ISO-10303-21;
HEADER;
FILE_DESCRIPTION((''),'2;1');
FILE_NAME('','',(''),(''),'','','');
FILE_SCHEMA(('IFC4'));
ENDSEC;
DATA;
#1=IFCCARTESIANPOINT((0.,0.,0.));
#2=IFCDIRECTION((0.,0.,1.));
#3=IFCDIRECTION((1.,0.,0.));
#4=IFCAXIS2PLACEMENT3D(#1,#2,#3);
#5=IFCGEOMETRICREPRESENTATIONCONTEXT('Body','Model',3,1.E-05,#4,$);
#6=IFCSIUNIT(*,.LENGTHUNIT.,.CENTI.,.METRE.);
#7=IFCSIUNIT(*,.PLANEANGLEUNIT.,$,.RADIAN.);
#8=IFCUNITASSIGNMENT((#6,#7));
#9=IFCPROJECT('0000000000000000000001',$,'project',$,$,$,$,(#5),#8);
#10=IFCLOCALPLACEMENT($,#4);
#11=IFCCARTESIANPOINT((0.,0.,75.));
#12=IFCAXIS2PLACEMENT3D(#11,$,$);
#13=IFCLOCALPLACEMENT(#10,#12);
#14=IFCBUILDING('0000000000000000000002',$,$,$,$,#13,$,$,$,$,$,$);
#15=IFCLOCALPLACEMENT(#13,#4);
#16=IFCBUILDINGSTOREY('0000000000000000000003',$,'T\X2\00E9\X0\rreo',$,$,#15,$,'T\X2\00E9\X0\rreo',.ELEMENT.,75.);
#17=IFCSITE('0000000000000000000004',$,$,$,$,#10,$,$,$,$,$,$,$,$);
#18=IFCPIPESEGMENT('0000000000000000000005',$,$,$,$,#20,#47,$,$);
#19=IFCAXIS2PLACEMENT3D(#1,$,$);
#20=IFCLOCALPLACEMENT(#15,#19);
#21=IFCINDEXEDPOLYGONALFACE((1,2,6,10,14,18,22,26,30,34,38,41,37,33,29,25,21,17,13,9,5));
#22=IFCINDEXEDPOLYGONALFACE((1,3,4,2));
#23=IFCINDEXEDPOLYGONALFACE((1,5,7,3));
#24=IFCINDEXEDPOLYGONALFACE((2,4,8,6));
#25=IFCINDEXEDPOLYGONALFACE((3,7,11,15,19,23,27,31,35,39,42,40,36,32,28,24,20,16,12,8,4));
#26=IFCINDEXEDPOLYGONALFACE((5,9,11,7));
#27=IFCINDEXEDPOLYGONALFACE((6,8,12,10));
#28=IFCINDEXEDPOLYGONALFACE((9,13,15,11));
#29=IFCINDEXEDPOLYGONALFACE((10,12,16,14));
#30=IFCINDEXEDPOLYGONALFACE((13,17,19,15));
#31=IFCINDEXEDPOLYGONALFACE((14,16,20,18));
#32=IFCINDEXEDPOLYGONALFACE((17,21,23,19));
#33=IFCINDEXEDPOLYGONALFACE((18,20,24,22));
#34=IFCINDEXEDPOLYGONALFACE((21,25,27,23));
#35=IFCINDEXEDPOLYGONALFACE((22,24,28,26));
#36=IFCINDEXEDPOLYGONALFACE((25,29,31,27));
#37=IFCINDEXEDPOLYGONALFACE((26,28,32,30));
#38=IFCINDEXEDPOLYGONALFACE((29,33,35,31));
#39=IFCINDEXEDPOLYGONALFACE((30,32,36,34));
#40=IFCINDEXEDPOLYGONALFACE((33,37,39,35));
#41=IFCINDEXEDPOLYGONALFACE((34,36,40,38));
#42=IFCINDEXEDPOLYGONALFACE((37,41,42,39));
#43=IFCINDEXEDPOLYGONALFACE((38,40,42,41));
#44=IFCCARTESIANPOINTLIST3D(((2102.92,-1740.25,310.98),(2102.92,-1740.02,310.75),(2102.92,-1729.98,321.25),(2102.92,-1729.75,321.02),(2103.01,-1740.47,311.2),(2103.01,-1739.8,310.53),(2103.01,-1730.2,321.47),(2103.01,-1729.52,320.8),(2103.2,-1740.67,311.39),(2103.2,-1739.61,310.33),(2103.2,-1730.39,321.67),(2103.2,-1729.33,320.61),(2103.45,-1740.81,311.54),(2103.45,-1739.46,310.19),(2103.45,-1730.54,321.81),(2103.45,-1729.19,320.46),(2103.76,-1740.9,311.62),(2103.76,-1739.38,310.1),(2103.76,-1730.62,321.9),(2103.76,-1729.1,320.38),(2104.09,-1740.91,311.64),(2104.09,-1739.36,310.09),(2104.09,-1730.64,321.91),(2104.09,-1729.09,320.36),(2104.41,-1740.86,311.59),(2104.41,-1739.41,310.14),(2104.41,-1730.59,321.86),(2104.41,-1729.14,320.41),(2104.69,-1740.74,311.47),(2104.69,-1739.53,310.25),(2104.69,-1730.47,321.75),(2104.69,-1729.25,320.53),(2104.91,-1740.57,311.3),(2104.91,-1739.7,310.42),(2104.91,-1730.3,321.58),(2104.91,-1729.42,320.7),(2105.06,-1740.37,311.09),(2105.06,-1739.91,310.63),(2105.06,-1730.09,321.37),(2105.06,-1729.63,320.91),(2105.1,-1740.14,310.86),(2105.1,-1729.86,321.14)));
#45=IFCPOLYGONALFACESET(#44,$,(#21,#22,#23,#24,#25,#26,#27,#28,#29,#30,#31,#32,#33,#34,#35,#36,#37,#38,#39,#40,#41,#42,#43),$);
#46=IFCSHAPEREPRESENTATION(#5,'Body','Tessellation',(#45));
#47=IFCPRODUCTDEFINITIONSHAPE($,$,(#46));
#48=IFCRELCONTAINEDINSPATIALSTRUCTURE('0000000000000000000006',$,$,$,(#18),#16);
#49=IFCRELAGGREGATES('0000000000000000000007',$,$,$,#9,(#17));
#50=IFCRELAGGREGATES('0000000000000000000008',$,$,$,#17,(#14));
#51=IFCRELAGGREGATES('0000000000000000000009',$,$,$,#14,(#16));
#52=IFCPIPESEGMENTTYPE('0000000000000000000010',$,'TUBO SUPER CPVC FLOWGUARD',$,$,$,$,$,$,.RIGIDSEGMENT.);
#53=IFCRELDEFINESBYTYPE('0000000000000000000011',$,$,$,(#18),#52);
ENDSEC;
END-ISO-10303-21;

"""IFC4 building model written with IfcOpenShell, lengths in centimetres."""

from ifc_helpers import new_model, si_unit, frame, origin_with_axes, origin_2d_with_axis, place, context, project, spatial, circle, extrude, type_object, element, save


model = new_model("IFC4")

# Units and contexts
model_context = context("Model", 3, precision=1e-05, world=origin_with_axes(), identifier="Body")
ifc_project = project(units=[si_unit("LENGTHUNIT", "METRE", prefix="CENTI"), si_unit("PLANEANGLEUNIT", "RADIAN")], contexts=[model_context])

# Site, building, storey
site_placement = place(None, origin_with_axes())
site = spatial("IfcSite", under=ifc_project, at=site_placement)
building_placement = place(site_placement, frame((0.0, 0.0, 75.0)))
building = spatial("IfcBuilding", under=site, at=building_placement)
storey_placement = place(building_placement, origin_with_axes())
storey = spatial("IfcBuildingStorey", under=building, at=storey_placement, Name="Térreo", LongName="Térreo", CompositionType="ELEMENT", Elevation=75.0)

# Pipe segment
pipe_segment_type_1 = type_object("IfcPipeSegmentType", Name="TUBO SUPER CPVC FLOWGUARD", PredefinedType="RIGIDSEGMENT")
pipe_segment_1_placement = place(storey_placement, frame((2104.0, -1735.0, 321.92), z_axis=(0.0, 0.0, 1.0), x_axis=(1.0, 0.0, 0.0)))
element("IfcPipeSegment", 1, at=pipe_segment_1_placement, inside=storey, type_object=pipe_segment_type_1, context=model_context, shape_type="SolidModel", body=[
    extrude(circle(Radius=1.1, at=origin_2d_with_axis()), frame((0.0, 5.14, -0.78), z_axis=(0.0, -0.707107, -0.707107), x_axis=(1.0, 0.0, 0.0)), (0.0, 0.0, 1.0), 14.53),
])

save(model, "model.ifc")
